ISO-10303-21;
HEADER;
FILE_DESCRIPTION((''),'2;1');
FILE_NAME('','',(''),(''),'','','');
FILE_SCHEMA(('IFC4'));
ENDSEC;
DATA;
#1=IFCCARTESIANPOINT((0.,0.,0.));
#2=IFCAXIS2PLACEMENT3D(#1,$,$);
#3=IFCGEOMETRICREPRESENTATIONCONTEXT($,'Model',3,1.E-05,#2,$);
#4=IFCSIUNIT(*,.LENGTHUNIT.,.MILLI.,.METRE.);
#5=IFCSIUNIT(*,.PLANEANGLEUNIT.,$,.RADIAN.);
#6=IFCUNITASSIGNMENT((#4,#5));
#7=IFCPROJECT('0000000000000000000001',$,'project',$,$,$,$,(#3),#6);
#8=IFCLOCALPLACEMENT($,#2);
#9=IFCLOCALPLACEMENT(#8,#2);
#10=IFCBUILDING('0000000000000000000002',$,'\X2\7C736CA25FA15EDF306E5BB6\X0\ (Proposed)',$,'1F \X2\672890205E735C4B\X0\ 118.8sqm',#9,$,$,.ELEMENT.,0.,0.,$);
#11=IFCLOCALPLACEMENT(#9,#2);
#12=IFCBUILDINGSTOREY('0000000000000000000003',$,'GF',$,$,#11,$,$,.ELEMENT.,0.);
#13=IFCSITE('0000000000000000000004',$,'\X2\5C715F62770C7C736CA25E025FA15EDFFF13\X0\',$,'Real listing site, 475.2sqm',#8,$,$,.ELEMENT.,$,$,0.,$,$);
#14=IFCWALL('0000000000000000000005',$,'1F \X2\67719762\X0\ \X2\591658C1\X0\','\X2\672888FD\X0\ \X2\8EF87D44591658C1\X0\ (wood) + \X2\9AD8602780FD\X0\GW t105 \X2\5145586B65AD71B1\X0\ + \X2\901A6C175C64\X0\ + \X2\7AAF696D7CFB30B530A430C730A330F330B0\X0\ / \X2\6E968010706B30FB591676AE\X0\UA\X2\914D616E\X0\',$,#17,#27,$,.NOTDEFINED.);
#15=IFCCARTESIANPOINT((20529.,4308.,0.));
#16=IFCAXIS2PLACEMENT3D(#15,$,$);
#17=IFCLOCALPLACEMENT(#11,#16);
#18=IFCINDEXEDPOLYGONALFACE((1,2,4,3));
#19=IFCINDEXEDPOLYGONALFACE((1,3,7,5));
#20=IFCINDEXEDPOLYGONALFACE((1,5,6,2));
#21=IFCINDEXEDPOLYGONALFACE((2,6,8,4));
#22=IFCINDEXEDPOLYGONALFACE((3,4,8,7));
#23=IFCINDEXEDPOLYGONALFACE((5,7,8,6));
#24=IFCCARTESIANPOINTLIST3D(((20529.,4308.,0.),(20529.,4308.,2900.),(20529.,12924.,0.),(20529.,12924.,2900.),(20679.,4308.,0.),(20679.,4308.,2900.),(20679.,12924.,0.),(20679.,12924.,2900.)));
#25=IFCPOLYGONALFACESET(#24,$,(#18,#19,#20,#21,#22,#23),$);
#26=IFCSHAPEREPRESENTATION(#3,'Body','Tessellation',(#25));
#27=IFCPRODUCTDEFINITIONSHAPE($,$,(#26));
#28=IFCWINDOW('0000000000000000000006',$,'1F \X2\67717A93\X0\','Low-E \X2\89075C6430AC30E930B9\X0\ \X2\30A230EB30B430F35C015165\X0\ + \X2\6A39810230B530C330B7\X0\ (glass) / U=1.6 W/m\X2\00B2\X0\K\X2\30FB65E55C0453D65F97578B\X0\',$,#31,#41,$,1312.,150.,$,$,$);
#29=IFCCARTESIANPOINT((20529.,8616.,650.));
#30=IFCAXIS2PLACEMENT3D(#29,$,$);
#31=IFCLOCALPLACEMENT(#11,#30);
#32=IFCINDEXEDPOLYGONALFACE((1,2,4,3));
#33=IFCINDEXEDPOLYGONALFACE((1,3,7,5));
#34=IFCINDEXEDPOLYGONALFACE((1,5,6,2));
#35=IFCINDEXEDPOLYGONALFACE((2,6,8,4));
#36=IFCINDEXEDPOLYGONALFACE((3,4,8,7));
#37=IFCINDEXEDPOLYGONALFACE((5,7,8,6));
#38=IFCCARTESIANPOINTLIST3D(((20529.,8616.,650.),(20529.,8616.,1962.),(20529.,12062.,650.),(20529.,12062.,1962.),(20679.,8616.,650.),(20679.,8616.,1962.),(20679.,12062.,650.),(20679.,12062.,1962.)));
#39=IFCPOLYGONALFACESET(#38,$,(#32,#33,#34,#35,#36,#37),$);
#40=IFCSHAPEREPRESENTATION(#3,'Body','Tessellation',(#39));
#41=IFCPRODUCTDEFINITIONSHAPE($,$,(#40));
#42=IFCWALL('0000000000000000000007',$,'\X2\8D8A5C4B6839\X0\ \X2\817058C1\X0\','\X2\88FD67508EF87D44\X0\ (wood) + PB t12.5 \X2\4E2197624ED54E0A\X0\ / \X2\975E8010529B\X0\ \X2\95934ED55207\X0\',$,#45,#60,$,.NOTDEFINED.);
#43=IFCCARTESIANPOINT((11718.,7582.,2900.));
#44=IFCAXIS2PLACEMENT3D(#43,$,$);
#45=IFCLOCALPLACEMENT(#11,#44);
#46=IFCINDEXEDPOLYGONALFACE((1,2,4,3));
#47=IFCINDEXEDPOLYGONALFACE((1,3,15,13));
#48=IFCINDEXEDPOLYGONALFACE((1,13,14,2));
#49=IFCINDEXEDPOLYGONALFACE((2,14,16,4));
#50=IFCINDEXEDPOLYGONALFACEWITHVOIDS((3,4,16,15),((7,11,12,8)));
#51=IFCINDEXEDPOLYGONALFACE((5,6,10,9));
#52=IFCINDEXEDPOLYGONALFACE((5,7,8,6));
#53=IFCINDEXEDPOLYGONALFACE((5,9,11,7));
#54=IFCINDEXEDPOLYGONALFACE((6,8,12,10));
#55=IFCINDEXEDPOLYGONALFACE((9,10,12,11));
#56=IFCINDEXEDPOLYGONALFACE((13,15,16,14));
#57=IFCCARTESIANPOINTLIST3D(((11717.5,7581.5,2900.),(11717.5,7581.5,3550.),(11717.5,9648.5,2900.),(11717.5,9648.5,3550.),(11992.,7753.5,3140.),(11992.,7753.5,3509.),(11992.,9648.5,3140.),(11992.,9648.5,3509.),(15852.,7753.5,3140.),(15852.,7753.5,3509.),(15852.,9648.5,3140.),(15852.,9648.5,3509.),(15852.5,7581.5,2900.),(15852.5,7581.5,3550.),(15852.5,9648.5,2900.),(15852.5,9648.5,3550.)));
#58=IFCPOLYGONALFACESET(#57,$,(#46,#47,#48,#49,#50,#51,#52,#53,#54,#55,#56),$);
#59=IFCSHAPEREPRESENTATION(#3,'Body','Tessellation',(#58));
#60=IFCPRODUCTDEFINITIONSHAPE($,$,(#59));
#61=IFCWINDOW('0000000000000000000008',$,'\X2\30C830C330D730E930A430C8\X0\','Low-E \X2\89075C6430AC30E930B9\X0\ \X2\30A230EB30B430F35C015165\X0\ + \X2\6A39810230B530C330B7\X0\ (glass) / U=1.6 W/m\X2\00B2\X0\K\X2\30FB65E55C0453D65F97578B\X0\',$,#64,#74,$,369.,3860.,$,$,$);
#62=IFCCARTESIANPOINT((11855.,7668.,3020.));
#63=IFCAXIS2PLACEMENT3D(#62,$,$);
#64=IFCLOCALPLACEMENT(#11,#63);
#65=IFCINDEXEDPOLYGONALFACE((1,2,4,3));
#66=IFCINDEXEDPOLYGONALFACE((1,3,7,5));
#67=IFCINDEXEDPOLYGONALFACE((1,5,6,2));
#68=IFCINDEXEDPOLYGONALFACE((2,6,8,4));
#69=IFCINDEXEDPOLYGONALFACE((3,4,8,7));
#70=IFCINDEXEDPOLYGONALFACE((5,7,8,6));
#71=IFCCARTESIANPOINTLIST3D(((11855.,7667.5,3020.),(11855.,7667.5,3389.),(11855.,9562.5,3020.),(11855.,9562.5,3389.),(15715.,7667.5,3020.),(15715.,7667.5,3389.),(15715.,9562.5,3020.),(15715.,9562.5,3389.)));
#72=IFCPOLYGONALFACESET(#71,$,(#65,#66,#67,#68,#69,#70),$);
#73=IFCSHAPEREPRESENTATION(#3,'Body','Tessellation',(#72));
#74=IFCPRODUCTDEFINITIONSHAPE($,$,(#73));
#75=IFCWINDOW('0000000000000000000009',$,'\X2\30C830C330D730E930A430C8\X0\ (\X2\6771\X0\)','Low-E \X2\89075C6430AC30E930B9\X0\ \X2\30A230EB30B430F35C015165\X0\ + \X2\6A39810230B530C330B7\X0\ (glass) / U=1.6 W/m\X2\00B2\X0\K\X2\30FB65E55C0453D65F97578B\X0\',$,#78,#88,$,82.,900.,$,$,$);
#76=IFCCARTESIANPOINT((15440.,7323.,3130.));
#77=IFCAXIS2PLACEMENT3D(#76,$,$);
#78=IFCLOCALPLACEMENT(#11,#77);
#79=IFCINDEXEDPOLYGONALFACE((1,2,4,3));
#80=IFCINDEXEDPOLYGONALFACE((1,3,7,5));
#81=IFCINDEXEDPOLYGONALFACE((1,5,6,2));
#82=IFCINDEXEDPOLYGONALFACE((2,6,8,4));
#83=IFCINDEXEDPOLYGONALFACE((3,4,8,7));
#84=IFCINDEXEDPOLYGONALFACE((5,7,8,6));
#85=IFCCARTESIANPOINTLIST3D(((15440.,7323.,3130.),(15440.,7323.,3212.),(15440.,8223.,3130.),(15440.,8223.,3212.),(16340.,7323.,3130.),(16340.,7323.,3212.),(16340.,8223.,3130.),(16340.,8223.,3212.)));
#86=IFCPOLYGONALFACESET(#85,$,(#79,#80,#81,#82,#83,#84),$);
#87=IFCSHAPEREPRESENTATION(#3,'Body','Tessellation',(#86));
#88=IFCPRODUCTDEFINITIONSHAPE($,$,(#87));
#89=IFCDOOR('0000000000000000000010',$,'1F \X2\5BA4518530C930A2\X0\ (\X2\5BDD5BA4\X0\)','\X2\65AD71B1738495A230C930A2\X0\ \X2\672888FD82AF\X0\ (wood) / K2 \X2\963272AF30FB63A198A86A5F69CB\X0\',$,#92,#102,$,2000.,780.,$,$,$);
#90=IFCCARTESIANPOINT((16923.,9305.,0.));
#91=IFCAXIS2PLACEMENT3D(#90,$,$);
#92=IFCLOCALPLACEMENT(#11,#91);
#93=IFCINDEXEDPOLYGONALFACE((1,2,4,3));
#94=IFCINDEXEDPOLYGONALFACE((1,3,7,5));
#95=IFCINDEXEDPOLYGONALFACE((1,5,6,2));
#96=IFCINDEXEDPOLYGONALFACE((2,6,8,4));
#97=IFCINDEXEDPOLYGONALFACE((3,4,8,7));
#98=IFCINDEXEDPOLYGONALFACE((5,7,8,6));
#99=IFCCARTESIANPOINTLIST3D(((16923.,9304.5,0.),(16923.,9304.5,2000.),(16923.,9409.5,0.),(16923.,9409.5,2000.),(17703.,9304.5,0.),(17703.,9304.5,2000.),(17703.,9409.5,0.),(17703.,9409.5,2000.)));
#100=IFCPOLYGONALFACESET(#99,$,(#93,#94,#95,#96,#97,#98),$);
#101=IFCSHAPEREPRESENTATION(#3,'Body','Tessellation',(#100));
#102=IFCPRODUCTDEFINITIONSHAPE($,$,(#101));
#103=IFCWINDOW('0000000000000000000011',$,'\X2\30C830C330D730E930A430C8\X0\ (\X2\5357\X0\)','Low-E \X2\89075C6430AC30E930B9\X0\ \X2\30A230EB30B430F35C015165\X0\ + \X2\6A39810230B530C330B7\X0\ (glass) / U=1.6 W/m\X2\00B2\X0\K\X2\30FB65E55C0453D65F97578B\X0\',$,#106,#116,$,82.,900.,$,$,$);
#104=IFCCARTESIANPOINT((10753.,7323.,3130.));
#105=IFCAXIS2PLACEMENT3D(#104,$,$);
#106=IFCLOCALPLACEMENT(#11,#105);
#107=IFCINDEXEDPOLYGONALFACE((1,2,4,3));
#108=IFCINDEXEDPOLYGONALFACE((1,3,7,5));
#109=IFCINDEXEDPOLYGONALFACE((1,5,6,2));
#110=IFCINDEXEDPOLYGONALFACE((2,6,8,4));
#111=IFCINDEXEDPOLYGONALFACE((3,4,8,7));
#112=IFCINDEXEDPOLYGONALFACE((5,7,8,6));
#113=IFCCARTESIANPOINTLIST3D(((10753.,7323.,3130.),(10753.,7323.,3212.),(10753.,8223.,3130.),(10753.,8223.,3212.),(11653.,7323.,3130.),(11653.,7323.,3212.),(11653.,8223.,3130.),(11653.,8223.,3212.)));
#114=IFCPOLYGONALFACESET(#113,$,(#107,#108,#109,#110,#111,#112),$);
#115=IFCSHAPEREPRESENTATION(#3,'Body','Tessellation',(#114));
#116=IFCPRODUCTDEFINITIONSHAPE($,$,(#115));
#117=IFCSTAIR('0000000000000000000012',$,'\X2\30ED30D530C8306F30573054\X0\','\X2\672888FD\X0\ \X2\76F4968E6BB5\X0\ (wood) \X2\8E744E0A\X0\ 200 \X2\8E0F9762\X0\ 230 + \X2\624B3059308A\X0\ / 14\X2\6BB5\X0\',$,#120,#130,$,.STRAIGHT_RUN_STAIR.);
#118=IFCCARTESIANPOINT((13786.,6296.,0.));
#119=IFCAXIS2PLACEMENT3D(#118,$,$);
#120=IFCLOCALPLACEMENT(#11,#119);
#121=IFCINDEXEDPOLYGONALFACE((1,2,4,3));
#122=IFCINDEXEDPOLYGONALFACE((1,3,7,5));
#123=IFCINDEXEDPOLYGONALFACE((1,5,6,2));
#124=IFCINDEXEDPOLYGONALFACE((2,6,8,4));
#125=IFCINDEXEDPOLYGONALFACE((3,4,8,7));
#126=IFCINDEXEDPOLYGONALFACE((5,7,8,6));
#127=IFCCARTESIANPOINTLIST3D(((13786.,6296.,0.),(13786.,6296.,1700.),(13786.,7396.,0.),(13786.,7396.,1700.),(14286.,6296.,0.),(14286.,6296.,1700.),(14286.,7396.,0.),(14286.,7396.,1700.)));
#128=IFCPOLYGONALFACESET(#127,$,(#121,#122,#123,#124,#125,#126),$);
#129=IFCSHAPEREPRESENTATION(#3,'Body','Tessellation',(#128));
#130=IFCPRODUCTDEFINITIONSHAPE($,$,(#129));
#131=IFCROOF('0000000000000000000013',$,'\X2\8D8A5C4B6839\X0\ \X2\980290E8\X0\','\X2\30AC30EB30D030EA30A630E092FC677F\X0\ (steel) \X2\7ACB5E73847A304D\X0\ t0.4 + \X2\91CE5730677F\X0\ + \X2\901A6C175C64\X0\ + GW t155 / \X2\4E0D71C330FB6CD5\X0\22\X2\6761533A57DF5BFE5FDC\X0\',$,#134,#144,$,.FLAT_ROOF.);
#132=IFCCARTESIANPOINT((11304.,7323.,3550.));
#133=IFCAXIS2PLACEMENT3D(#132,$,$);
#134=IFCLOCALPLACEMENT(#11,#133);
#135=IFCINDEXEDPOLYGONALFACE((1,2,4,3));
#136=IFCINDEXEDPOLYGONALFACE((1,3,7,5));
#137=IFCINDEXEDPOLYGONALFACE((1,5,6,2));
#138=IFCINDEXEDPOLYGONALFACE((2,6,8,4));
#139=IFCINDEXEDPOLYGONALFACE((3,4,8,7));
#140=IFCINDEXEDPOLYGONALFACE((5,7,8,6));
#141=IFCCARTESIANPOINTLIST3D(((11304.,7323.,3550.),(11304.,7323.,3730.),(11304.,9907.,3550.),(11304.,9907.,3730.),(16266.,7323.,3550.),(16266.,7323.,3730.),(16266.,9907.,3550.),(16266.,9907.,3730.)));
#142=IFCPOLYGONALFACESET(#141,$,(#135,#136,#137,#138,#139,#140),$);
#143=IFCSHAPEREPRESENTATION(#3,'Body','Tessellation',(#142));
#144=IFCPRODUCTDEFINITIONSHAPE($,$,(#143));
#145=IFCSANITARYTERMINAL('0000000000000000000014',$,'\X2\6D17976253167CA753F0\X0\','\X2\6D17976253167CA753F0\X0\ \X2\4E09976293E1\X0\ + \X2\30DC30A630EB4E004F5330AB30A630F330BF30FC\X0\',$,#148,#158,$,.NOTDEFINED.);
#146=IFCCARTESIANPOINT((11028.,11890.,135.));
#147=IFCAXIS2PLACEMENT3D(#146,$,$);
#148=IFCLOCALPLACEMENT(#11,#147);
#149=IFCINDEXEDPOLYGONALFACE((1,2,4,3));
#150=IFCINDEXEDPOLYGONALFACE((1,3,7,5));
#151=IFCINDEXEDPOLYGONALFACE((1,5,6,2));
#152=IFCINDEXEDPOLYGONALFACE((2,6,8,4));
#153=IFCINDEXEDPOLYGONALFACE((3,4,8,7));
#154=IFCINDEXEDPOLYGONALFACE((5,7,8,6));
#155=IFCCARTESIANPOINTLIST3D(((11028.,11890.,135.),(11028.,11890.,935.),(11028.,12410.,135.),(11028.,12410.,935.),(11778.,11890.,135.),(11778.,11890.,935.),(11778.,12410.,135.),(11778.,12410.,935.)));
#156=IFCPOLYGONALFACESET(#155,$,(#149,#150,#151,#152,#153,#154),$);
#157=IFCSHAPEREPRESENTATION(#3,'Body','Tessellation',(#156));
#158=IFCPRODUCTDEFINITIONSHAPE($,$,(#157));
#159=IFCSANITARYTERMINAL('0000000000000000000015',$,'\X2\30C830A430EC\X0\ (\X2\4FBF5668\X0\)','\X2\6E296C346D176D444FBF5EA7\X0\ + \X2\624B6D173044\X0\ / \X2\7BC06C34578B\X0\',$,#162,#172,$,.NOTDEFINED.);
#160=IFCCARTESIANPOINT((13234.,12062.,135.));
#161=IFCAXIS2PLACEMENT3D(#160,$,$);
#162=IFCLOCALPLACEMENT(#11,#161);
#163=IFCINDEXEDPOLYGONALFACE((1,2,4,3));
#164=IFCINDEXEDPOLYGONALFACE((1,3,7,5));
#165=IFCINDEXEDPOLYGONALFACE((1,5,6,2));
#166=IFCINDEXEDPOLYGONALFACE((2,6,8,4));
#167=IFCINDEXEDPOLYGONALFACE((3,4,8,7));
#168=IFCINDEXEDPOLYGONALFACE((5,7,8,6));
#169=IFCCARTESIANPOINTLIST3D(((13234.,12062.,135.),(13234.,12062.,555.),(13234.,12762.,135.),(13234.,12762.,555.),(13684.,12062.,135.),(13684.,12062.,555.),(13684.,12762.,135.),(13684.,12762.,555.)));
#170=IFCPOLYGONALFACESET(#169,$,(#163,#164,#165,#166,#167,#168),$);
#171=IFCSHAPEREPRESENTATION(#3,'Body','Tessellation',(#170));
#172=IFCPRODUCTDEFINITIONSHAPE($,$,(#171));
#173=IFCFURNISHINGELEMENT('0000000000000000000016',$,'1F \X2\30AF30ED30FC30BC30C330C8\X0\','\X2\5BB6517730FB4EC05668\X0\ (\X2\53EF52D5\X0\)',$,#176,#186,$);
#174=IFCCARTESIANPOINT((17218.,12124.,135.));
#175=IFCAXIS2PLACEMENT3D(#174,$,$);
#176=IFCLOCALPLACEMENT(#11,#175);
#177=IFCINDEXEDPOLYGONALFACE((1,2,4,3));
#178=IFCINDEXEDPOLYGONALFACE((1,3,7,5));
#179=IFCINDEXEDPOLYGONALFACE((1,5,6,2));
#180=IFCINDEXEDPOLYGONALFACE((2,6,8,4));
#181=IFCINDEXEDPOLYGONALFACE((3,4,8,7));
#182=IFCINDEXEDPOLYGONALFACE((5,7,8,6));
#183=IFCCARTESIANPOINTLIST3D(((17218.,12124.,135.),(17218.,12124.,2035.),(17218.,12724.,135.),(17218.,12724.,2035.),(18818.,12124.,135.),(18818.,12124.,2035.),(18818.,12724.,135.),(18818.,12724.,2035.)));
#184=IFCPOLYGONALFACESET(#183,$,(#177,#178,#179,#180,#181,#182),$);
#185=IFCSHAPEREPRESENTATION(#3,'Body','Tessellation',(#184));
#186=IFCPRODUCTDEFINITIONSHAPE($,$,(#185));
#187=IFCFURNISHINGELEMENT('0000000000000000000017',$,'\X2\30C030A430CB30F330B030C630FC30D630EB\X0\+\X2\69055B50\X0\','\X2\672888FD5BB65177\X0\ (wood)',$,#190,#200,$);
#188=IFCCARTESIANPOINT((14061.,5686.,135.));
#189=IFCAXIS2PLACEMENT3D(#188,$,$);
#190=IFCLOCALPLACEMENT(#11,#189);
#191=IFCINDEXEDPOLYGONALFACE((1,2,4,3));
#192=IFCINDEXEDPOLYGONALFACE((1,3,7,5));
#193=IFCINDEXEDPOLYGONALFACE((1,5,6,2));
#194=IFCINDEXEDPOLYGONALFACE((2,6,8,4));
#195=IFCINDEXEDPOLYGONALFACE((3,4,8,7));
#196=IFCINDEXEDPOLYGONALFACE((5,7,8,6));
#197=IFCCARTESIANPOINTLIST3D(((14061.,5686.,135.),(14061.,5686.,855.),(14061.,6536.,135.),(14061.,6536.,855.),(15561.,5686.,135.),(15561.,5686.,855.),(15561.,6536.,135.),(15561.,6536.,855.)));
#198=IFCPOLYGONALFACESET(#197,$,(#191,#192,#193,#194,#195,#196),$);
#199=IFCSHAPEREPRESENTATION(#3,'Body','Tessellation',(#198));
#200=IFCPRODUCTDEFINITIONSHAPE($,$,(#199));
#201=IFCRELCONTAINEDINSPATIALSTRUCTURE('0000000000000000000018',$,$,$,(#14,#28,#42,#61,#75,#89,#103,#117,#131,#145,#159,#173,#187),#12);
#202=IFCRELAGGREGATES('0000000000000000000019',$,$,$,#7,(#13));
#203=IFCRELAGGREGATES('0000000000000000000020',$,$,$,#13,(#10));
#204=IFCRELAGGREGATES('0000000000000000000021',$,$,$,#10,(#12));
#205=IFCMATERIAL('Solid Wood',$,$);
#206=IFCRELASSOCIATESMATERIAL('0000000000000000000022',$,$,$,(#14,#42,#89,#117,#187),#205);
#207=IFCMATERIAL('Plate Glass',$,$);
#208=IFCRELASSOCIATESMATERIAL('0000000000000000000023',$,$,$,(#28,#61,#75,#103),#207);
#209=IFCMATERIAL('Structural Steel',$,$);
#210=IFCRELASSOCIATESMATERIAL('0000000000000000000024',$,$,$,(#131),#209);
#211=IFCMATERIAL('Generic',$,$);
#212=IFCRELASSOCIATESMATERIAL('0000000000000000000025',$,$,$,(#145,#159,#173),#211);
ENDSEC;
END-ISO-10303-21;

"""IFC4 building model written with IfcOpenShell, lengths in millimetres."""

from ifc_helpers import new_model, si_unit, frame, frame_2d, origin, place, context, project, spatial, rectangle, extrude, material, element, fill, save


model = new_model("IFC4")

# Units and contexts
model_context = context("Model", 3, precision=1e-05, world=origin())
ifc_project = project(units=[si_unit("LENGTHUNIT", "METRE", prefix="MILLI"), si_unit("PLANEANGLEUNIT", "RADIAN")], contexts=[model_context])

# Site, building, storey
site_placement = place(None, origin())
site = spatial("IfcSite", under=ifc_project, at=site_placement, Name="山形県米沢市御廟３", ObjectType="Real listing site, 475.2sqm", CompositionType="ELEMENT", RefElevation=0.0)
building_placement = place(site_placement, origin())
building = spatial("IfcBuilding", under=site, at=building_placement, Name="米沢御廟の家 (Proposed)", ObjectType="1F 木造平屋 118.8sqm", CompositionType="ELEMENT", ElevationOfRefHeight=0.0, ElevationOfTerrain=0.0)
storey_placement = place(building_placement, origin())
storey = spatial("IfcBuildingStorey", under=building, at=storey_placement, Name="GF", CompositionType="ELEMENT", Elevation=0.0)

# Wall, opening, window
ifc_material_1 = material(Name="Solid Wood")
wall_1_placement = place(storey_placement, frame((20529.0, 4308.0, 0.0)))
wall_1 = element("IfcWall", 1, at=wall_1_placement, inside=storey, material=ifc_material_1, Name="1F 東面 外壁", Description="木製 軸組外壁 (wood) + 高性能GW t105 充填断熱 + 通気層 + 窯業系サイディング / 準耐火・外皮UA配慮", PredefinedType="NOTDEFINED", context=model_context, shape_type="SweptSolid", body=[
    extrude(rectangle(XDim=150.0, YDim=8616.0, at=frame_2d((75.0, 4308.0))), frame((20529.0, 4308.0, 0.0)), (0.0, 0.0, 1.0), 2900.0),
])
opening_1_placement = place(storey_placement, frame((20529.0, 8616.0, 650.0)))
opening_1 = element("IfcOpeningElement", 2, at=opening_1_placement, cuts=wall_1, PredefinedType="NOTDEFINED", context=model_context, shape_type="SweptSolid", body=[
    extrude(rectangle(XDim=150.0, YDim=3446.0, at=frame_2d((75.0, 1723.0))), frame((20529.0, 8616.0, 650.0)), (0.0, 0.0, 1.0), 1312.0),
])
ifc_material_2 = material(Name="Plate Glass")
window_1_placement = place(storey_placement, frame((20529.0, 8616.0, 650.0)))
window_1 = element("IfcWindow", 3, at=window_1_placement, inside=storey, material=ifc_material_2, Name="1F 東窓", Description="Low-E 複層ガラス アルゴン封入 + 樹脂サッシ (glass) / U=1.6 W/m²K・日射取得型", OverallHeight=1312.0, OverallWidth=150.0, context=model_context, shape_type="SweptSolid", body=[
    extrude(rectangle(XDim=150.0, YDim=3446.0, at=frame_2d((75.0, 1723.0))), frame((20529.0, 8616.0, 650.0)), (0.0, 0.0, 1.0), 1312.0),
])
fill(opening_1, window_1)

# Wall, openings, windows
wall_2_placement = place(storey_placement, frame((11718.0, 7582.0, 2900.0)))
wall_2 = element("IfcWall", 4, at=wall_2_placement, inside=storey, material=ifc_material_1, Name="越屋根 腰壁", Description="製材軸組 (wood) + PB t12.5 両面仕上 / 非耐力 間仕切", PredefinedType="NOTDEFINED", context=model_context, shape_type="SweptSolid", body=[
    extrude(rectangle(XDim=4135.0, YDim=2067.0, at=frame_2d((2067.0, 1033.0))), frame((11718.0, 7582.0, 2900.0)), (0.0, 0.0, 1.0), 650.0),
])
opening_2_placement = place(storey_placement, frame((11855.0, 7668.0, 3020.0)))
opening_2 = element("IfcOpeningElement", 5, at=opening_2_placement, cuts=wall_2, PredefinedType="NOTDEFINED", context=model_context, shape_type="SweptSolid", body=[
    extrude(rectangle(XDim=3860.0, YDim=1895.0, at=frame_2d((1930.0, 947.0))), frame((11855.0, 7668.0, 3020.0)), (0.0, 0.0, 1.0), 369.0),
])
opening_3_placement = place(storey_placement, frame((15440.0, 7323.0, 3130.0)))
opening_3 = element("IfcOpeningElement", 6, at=opening_3_placement, cuts=wall_2, PredefinedType="NOTDEFINED", context=model_context, shape_type="SweptSolid", body=[
    extrude(rectangle(XDim=900.0, YDim=900.0, at=frame_2d((450.0, 450.0))), frame((15440.0, 7323.0, 3130.0)), (0.0, 0.0, 1.0), 82.0),
])
window_2_placement = place(storey_placement, frame((11855.0, 7668.0, 3020.0)))
window_2 = element("IfcWindow", 7, at=window_2_placement, inside=storey, material=ifc_material_2, Name="トップライト", Description="Low-E 複層ガラス アルゴン封入 + 樹脂サッシ (glass) / U=1.6 W/m²K・日射取得型", OverallHeight=369.0, OverallWidth=3860.0, context=model_context, shape_type="SweptSolid", body=[
    extrude(rectangle(XDim=3860.0, YDim=1895.0, at=frame_2d((1930.0, 947.0))), frame((11855.0, 7668.0, 3020.0)), (0.0, 0.0, 1.0), 369.0),
])
fill(opening_2, window_2)
window_3_placement = place(storey_placement, frame((15440.0, 7323.0, 3130.0)))
window_3 = element("IfcWindow", 8, at=window_3_placement, inside=storey, material=ifc_material_2, Name="トップライト (東)", Description="Low-E 複層ガラス アルゴン封入 + 樹脂サッシ (glass) / U=1.6 W/m²K・日射取得型", OverallHeight=82.0, OverallWidth=900.0, context=model_context, shape_type="SweptSolid", body=[
    extrude(rectangle(XDim=900.0, YDim=900.0, at=frame_2d((450.0, 450.0))), frame((15440.0, 7323.0, 3130.0)), (0.0, 0.0, 1.0), 82.0),
])
fill(opening_3, window_3)

# Door
door_placement = place(storey_placement, frame((16923.0, 9305.0, 0.0)))
element("IfcDoor", 9, at=door_placement, inside=storey, material=ifc_material_1, Name="1F 室内ドア (寝室)", Description="断熱玄関ドア 木製芯 (wood) / K2 防犯・採風機構", OverallHeight=2000.0, OverallWidth=780.0, context=model_context, shape_type="SweptSolid", body=[
    extrude(rectangle(XDim=780.0, YDim=105.0, at=frame_2d((390.0, 52.0))), frame((16923.0, 9305.0, 0.0)), (0.0, 0.0, 1.0), 2000.0),
])

# Window
window_4_placement = place(storey_placement, frame((10753.0, 7323.0, 3130.0)))
element("IfcWindow", 10, at=window_4_placement, inside=storey, material=ifc_material_2, Name="トップライト (南)", Description="Low-E 複層ガラス アルゴン封入 + 樹脂サッシ (glass) / U=1.6 W/m²K・日射取得型", OverallHeight=82.0, OverallWidth=900.0, context=model_context, shape_type="SweptSolid", body=[
    extrude(rectangle(XDim=900.0, YDim=900.0, at=frame_2d((450.0, 450.0))), frame((10753.0, 7323.0, 3130.0)), (0.0, 0.0, 1.0), 82.0),
])

# Stair
stair_placement = place(storey_placement, frame((13786.0, 6296.0, 0.0)))
element("IfcStair", 11, at=stair_placement, inside=storey, material=ifc_material_1, Name="ロフトはしご", Description="木製 直階段 (wood) 蹴上 200 踏面 230 + 手すり / 14段", PredefinedType="STRAIGHT_RUN_STAIR", context=model_context, shape_type="SweptSolid", body=[
    extrude(rectangle(XDim=500.0, YDim=1100.0, at=frame_2d((250.0, 550.0))), frame((13786.0, 6296.0, 0.0)), (0.0, 0.0, 1.0), 1700.0),
])

# Roof
ifc_material_3 = material(Name="Structural Steel")
roof_placement = place(storey_placement, frame((11304.0, 7323.0, 3550.0)))
element("IfcRoof", 12, at=roof_placement, inside=storey, material=ifc_material_3, Name="越屋根 頂部", Description="ガルバリウム鋼板 (steel) 立平葺き t0.4 + 野地板 + 通気層 + GW t155 / 不燃・法22条区域対応", PredefinedType="FLAT_ROOF", context=model_context, shape_type="SweptSolid", body=[
    extrude(rectangle(XDim=4962.0, YDim=2584.0, at=frame_2d((2481.0, 1292.0))), frame((11304.0, 7323.0, 3550.0)), (0.0, 0.0, 1.0), 180.0),
])

# Sanitary terminals
ifc_material_4 = material(Name="Generic")
sanitary_terminal_1_placement = place(storey_placement, frame((11028.0, 11890.0, 135.0)))
element("IfcSanitaryTerminal", 13, at=sanitary_terminal_1_placement, inside=storey, material=ifc_material_4, Name="洗面化粧台", Description="洗面化粧台 三面鏡 + ボウル一体カウンター", PredefinedType="NOTDEFINED", context=model_context, shape_type="SweptSolid", body=[
    extrude(rectangle(XDim=750.0, YDim=520.0, at=frame_2d((375.0, 260.0))), frame((11028.0, 11890.0, 135.0)), (0.0, 0.0, 1.0), 800.0),
])
sanitary_terminal_2_placement = place(storey_placement, frame((13234.0, 12062.0, 135.0)))
element("IfcSanitaryTerminal", 14, at=sanitary_terminal_2_placement, inside=storey, material=ifc_material_4, Name="トイレ (便器)", Description="温水洗浄便座 + 手洗い / 節水型", PredefinedType="NOTDEFINED", context=model_context, shape_type="SweptSolid", body=[
    extrude(rectangle(XDim=450.0, YDim=700.0, at=frame_2d((225.0, 350.0))), frame((13234.0, 12062.0, 135.0)), (0.0, 0.0, 1.0), 420.0),
])

# Furnishing elements
furnishing_1_placement = place(storey_placement, frame((17218.0, 12124.0, 135.0)))
element("IfcFurnishingElement", 15, at=furnishing_1_placement, inside=storey, material=ifc_material_4, Name="1F クローゼット", Description="家具・什器 (可動)", context=model_context, shape_type="SweptSolid", body=[
    extrude(rectangle(XDim=1600.0, YDim=600.0, at=frame_2d((800.0, 300.0))), frame((17218.0, 12124.0, 135.0)), (0.0, 0.0, 1.0), 1900.0),
])
furnishing_2_placement = place(storey_placement, frame((14061.0, 5686.0, 135.0)))
element("IfcFurnishingElement", 16, at=furnishing_2_placement, inside=storey, material=ifc_material_1, Name="ダイニングテーブル+椅子", Description="木製家具 (wood)", context=model_context, shape_type="SweptSolid", body=[
    extrude(rectangle(XDim=1500.0, YDim=850.0, at=frame_2d((750.0, 425.0))), frame((14061.0, 5686.0, 135.0)), (0.0, 0.0, 1.0), 720.0),
])

save(model, "model.ifc")
